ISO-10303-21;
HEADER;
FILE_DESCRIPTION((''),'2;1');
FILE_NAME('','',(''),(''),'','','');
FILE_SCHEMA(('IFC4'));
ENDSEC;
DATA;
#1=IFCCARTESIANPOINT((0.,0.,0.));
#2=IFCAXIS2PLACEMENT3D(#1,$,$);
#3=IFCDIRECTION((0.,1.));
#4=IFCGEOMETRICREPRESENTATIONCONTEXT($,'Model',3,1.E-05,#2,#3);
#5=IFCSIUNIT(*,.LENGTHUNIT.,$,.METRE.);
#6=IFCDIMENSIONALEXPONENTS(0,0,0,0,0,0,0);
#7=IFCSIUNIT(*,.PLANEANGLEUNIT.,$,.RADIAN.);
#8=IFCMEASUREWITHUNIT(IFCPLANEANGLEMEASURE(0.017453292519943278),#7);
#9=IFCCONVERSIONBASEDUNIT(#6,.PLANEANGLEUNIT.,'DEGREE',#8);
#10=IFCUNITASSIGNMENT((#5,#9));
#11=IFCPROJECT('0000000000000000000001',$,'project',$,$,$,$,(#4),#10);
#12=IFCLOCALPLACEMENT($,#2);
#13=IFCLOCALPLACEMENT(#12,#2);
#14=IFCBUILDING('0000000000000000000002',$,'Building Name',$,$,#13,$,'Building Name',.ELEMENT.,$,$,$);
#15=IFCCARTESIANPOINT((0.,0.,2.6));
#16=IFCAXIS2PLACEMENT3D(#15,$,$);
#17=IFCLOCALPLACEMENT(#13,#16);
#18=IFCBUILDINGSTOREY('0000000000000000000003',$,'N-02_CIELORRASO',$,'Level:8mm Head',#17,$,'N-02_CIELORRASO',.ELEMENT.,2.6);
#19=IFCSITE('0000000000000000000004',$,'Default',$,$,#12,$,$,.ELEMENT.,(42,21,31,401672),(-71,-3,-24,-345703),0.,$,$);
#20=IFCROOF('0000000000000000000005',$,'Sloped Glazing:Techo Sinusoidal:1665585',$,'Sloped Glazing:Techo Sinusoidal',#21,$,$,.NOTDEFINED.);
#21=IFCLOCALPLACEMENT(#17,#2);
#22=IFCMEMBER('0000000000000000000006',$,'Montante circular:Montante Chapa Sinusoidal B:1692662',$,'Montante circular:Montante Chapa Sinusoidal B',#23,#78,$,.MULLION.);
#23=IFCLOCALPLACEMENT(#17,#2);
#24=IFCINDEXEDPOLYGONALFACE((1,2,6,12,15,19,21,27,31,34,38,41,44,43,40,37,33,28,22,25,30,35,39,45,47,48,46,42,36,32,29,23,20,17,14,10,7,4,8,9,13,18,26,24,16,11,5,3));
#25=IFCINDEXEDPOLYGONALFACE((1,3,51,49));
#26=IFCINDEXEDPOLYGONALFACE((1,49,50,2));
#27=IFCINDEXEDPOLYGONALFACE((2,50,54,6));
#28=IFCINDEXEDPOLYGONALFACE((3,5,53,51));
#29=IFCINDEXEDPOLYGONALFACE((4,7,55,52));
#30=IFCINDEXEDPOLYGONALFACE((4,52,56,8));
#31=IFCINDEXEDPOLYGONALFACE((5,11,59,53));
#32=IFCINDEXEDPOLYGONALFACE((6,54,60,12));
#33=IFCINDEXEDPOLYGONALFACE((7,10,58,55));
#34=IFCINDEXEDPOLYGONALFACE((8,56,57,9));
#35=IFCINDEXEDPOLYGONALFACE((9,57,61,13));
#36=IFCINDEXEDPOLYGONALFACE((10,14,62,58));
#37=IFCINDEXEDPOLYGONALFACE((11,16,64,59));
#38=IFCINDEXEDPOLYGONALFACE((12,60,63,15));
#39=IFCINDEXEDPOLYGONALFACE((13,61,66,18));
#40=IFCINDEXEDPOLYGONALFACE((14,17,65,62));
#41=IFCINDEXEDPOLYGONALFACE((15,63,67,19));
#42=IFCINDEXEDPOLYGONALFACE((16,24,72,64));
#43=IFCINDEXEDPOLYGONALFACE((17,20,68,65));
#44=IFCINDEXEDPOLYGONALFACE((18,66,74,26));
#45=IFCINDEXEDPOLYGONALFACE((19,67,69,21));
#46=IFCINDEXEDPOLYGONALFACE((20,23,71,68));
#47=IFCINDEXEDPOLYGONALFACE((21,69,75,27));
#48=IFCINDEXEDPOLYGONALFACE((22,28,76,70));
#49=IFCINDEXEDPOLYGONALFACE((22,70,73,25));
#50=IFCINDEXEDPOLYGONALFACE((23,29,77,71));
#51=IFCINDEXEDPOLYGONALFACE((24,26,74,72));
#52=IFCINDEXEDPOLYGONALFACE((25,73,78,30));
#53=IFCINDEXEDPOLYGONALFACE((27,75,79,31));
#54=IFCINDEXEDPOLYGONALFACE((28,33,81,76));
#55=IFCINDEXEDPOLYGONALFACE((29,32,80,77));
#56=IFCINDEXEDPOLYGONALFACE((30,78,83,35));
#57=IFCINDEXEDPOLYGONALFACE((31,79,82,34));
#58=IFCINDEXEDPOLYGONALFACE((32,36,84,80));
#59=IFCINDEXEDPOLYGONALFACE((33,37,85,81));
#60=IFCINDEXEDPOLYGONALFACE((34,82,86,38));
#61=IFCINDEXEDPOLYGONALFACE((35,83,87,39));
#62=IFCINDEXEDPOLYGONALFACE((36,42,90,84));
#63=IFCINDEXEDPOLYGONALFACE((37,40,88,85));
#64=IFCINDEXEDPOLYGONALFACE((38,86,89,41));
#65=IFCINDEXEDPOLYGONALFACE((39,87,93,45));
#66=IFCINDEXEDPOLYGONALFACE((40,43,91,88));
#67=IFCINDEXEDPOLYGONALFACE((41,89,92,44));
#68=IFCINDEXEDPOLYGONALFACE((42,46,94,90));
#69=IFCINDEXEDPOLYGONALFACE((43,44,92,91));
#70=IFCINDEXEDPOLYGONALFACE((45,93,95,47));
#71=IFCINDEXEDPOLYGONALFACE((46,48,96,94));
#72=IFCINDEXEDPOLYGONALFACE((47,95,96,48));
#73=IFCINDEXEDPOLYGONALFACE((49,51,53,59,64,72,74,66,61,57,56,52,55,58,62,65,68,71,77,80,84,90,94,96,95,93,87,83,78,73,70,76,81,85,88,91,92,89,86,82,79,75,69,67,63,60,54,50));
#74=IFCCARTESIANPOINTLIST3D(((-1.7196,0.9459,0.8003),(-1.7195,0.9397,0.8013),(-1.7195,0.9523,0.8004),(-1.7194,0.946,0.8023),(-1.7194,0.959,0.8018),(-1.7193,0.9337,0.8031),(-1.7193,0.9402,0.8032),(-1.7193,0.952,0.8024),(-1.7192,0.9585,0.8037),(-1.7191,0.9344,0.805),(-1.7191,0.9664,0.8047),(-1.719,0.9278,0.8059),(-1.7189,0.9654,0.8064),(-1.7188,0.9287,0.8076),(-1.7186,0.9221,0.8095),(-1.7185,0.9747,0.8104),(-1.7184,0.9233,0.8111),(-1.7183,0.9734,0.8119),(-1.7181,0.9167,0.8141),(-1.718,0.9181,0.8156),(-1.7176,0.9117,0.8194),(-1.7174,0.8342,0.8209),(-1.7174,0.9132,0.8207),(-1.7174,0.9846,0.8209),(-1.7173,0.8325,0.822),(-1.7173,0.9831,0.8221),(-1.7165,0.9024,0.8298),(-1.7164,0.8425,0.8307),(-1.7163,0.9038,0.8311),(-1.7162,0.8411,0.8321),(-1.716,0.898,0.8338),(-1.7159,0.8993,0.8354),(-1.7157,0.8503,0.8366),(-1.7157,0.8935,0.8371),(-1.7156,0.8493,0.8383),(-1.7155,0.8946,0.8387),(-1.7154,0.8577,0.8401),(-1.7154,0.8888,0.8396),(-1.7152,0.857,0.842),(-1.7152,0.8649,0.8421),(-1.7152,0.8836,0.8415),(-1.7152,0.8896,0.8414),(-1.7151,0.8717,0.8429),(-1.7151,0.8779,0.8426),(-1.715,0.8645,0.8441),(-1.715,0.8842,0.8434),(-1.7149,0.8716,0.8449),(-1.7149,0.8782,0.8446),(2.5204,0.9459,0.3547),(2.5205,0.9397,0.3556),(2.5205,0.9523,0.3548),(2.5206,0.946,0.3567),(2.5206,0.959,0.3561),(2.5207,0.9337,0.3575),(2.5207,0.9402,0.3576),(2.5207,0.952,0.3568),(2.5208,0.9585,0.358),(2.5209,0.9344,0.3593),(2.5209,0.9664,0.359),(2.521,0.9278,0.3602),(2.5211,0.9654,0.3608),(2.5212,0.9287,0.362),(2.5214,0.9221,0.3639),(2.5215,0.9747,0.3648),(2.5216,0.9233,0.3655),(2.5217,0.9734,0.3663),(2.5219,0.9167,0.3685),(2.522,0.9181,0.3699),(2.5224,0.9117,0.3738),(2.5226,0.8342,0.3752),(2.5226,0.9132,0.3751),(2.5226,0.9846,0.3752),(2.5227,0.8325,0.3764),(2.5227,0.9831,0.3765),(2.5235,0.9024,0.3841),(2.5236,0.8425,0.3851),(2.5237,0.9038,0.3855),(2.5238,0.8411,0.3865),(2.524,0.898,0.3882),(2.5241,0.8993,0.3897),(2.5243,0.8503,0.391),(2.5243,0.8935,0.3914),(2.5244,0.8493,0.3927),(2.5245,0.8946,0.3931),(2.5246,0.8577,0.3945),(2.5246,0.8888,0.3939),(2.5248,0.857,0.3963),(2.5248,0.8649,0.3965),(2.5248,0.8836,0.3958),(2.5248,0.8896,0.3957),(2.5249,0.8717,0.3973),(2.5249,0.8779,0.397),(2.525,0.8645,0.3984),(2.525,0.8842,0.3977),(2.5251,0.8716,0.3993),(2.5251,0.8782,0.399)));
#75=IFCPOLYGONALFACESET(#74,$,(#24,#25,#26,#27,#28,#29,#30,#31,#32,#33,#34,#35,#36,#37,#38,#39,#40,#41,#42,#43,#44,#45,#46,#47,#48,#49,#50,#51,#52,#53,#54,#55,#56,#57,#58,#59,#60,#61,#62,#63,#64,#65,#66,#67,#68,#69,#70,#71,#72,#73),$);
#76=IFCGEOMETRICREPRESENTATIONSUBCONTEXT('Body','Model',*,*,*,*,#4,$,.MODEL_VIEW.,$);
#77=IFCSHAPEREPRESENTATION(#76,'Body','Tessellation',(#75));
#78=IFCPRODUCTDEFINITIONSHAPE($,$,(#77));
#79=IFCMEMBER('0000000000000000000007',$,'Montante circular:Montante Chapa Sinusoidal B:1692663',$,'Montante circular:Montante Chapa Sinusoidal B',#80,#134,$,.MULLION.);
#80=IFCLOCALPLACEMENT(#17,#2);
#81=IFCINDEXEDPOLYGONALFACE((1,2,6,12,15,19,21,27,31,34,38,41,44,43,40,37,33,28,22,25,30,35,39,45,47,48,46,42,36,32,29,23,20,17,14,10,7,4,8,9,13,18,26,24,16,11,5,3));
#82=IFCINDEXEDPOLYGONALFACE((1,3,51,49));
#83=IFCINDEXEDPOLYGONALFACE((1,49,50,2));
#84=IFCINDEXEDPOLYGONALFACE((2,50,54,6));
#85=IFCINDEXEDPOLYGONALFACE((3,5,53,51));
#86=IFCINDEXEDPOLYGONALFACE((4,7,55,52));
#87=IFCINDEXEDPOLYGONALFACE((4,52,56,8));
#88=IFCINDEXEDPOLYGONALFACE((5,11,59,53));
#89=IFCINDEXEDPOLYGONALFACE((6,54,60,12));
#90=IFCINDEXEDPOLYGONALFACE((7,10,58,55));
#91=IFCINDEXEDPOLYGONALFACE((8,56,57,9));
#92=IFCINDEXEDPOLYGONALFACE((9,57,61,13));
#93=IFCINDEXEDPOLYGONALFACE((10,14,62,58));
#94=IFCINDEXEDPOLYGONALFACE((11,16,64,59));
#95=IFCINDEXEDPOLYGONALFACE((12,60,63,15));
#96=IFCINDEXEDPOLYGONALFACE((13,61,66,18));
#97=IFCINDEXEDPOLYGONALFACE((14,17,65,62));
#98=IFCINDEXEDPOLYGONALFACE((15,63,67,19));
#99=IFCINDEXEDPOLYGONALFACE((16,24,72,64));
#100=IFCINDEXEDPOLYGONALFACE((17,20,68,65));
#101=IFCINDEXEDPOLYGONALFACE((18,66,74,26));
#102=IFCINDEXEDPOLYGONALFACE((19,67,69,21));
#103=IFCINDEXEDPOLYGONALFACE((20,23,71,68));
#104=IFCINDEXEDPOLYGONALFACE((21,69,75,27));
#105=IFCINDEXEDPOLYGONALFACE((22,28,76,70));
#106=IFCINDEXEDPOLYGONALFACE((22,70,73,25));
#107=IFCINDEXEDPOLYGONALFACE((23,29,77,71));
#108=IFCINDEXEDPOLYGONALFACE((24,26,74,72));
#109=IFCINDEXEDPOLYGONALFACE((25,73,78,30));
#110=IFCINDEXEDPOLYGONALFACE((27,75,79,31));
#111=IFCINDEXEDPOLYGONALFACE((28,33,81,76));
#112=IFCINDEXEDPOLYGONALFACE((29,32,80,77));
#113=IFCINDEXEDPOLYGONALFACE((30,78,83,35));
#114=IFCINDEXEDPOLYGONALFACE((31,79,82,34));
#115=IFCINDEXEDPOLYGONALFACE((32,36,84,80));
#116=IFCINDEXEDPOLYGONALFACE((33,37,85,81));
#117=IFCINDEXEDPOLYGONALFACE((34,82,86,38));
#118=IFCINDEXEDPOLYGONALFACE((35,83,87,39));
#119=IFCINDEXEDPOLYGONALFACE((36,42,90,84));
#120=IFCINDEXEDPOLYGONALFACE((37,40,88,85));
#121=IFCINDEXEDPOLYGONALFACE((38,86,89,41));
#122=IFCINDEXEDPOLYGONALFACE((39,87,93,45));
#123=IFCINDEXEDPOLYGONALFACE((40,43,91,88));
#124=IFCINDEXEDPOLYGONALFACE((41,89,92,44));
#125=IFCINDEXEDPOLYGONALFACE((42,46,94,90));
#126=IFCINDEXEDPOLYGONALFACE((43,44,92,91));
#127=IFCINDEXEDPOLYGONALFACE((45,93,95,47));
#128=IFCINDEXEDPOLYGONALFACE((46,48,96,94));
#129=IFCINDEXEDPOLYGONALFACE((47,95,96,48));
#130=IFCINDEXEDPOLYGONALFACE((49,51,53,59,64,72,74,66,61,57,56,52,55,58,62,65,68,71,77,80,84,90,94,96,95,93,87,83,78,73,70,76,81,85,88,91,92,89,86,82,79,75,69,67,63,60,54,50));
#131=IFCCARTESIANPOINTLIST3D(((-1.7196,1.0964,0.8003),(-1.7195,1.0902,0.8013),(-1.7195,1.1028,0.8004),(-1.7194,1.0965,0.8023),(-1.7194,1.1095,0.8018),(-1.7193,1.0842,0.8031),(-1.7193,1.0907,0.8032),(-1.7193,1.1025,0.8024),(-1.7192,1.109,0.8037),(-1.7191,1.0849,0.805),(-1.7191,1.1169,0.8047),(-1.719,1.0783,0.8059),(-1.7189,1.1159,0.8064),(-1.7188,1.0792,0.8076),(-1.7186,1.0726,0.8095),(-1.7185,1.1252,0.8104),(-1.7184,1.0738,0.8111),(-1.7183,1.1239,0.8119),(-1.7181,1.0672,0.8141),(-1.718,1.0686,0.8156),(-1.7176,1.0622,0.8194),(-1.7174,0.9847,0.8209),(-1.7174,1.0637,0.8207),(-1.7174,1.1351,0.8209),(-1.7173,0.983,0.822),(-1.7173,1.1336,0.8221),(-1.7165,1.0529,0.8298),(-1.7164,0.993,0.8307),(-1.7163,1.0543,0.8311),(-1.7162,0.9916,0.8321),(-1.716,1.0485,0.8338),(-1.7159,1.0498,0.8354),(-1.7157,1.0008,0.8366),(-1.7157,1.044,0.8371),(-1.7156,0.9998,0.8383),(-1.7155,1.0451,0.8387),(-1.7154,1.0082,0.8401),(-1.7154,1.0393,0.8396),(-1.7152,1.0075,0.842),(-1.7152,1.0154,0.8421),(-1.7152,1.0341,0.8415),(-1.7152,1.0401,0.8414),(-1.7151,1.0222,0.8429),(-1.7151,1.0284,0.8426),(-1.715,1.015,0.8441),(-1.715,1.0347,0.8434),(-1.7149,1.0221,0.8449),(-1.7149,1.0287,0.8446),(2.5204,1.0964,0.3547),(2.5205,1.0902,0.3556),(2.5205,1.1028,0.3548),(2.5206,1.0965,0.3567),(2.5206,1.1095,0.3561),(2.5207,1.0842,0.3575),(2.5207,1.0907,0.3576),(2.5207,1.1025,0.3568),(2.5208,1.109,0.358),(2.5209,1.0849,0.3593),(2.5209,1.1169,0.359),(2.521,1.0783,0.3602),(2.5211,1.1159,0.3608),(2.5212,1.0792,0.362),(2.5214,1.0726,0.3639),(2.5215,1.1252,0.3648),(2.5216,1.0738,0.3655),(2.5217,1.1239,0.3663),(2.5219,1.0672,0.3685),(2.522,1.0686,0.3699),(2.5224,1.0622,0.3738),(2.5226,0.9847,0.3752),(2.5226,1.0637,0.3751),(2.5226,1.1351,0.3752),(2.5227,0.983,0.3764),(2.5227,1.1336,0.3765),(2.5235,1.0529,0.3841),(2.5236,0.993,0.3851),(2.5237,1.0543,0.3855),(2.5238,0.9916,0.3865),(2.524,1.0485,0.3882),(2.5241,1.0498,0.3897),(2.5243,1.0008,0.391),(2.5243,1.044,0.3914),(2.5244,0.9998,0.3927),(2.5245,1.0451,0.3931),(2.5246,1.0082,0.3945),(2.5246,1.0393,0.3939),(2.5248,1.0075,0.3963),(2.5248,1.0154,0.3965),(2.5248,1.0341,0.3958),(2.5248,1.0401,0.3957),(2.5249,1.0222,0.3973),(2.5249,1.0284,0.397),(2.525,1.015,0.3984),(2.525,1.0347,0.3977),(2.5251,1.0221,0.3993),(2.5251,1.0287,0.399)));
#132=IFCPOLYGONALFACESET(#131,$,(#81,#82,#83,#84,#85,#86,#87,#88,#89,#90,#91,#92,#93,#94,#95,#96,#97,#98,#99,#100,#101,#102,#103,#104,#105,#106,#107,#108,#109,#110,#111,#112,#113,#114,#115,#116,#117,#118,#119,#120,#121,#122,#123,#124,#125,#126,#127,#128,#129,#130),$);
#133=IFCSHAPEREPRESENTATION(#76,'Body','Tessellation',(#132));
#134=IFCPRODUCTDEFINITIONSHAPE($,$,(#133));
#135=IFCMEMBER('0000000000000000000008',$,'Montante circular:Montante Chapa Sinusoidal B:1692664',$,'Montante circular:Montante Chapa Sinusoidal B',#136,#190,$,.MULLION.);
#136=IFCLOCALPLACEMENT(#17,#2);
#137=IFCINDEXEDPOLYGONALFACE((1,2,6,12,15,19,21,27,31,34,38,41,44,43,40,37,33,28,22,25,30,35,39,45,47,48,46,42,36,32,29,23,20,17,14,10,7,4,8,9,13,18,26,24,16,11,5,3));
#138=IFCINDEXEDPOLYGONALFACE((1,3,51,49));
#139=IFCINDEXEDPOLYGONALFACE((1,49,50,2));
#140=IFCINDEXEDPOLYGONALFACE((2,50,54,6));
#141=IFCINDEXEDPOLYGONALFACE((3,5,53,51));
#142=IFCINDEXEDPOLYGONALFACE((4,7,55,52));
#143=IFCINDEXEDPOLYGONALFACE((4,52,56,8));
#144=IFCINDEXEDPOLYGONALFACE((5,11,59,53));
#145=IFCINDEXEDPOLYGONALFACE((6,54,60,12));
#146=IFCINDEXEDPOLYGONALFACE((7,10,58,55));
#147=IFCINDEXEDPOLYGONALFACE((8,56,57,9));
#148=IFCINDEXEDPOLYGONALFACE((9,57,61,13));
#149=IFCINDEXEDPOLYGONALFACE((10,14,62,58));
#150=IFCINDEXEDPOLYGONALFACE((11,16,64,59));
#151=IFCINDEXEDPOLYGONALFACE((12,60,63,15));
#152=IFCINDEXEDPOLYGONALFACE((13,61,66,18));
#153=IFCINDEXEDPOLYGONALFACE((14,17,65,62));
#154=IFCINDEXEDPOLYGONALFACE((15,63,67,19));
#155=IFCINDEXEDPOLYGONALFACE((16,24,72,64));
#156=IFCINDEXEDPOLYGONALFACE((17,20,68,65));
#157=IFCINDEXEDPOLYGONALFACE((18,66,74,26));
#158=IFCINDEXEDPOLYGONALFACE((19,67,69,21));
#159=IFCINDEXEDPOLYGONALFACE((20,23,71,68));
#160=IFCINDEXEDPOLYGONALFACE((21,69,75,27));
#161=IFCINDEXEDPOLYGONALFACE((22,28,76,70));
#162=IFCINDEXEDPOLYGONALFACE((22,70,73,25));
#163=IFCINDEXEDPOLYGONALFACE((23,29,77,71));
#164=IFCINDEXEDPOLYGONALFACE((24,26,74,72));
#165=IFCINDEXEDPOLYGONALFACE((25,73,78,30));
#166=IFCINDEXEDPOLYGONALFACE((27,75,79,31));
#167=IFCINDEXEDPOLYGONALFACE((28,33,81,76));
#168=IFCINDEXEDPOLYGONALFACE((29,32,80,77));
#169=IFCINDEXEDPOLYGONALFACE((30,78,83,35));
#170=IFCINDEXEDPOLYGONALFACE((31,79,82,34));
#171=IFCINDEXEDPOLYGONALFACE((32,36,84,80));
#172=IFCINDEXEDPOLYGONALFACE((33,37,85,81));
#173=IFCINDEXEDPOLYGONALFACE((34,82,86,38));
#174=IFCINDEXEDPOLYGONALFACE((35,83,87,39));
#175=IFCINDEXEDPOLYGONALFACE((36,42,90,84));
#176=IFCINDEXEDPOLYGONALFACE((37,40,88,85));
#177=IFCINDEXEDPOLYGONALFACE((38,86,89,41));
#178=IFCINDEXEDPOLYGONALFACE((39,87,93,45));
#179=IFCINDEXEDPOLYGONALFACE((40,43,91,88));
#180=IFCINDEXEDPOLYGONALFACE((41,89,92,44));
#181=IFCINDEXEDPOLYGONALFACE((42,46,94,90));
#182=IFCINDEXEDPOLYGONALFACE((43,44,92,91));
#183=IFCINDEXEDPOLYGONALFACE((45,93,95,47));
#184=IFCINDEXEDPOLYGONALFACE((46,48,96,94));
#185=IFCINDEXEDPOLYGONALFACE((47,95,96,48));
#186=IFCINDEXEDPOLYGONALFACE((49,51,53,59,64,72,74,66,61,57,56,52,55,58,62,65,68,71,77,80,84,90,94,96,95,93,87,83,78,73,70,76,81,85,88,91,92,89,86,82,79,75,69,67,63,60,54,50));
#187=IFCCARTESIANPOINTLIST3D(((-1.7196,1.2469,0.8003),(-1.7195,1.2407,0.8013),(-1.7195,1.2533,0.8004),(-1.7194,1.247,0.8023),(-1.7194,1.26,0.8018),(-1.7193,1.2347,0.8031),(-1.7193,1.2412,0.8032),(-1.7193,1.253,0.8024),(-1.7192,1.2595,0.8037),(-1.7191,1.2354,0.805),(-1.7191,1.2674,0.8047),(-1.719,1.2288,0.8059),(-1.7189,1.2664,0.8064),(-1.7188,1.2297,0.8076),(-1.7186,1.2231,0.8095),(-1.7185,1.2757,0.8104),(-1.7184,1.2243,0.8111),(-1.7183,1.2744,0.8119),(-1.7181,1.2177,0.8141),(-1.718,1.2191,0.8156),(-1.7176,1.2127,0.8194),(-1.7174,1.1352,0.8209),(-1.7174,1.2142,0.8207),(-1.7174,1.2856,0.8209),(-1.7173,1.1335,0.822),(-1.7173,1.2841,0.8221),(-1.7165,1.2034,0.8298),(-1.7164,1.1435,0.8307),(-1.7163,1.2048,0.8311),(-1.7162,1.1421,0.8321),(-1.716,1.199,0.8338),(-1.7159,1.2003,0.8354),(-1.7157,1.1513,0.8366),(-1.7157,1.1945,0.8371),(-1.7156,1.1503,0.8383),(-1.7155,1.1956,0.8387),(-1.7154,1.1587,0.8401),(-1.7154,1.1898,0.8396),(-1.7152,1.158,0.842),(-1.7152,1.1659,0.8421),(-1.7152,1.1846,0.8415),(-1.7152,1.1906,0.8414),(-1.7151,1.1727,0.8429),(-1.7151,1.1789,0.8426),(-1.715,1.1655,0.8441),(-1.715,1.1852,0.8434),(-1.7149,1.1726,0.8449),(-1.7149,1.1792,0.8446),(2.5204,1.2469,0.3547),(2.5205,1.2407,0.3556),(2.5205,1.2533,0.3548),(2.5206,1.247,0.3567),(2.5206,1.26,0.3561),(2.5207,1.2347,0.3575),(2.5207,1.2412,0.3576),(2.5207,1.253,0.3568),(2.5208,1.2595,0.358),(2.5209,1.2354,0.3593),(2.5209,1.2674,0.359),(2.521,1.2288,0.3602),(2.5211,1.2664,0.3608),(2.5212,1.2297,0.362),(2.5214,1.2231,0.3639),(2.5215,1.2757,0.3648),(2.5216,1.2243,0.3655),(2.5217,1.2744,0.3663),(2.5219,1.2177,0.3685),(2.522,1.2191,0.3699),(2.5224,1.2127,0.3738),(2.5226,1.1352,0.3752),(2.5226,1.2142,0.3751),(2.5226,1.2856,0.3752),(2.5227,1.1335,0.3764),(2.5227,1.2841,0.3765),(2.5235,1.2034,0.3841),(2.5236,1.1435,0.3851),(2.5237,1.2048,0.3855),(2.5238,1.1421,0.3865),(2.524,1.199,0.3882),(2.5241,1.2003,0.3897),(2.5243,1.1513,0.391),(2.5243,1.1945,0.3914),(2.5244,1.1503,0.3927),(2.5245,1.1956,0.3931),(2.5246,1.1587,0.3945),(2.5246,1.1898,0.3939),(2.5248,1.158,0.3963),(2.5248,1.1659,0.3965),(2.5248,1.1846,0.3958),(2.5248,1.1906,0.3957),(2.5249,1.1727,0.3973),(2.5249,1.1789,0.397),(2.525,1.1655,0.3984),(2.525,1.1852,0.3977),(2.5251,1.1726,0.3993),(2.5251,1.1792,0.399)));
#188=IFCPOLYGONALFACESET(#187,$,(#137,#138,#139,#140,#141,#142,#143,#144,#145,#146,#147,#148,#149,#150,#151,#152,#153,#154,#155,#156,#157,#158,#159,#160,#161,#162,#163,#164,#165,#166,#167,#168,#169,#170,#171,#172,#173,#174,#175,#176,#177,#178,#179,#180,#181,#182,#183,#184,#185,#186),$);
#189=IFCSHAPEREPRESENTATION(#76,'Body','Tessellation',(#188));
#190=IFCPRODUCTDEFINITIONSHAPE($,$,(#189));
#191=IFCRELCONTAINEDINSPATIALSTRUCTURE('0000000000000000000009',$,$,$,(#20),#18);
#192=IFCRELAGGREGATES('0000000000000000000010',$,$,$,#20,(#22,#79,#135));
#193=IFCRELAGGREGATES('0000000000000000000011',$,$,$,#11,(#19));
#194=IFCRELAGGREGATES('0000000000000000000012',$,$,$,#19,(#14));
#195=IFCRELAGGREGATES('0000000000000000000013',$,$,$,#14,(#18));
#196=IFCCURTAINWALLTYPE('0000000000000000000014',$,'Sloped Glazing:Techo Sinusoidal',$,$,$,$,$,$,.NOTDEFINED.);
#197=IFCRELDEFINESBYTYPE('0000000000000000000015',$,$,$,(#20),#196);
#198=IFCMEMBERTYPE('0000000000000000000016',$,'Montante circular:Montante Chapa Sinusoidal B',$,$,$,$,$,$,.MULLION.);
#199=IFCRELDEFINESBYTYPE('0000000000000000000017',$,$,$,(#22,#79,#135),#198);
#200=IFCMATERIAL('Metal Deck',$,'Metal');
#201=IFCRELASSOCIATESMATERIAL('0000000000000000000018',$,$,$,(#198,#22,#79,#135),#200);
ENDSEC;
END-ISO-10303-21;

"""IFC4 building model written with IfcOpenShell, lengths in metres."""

from ifc_helpers import new_model, entity, si_unit, converted_unit, direction, frame, origin, place, context, subcontext, project, spatial, indexed_curve, outline, extrude, source, transform, mapped, material, type_object, type_shapes, element, aggregate, save


model = new_model("IFC4")

# Units and contexts
model_context = context("Model", 3, precision=1e-05, world=origin(), true_north=direction((0.0, 1.0)))
body_context = subcontext(model_context, "Body", "Model", "MODEL_VIEW")
ifc_project = project(units=[si_unit("LENGTHUNIT", "METRE"), converted_unit("PLANEANGLEUNIT", "DEGREE", entity("IfcPlaneAngleMeasure", 0.017453292519943278), si_unit("PLANEANGLEUNIT", "RADIAN"), dimensions=[0, 0, 0, 0, 0, 0, 0])], contexts=[model_context])

# Site, building, storey
site_placement = place(None, origin())
site = spatial("IfcSite", under=ifc_project, at=site_placement, Name="Default", CompositionType="ELEMENT", RefLatitude=(42, 21, 31, 401672), RefLongitude=(-71, -3, -24, -345703), RefElevation=0.0)
building_placement = place(site_placement, origin())
building = spatial("IfcBuilding", under=site, at=building_placement, Name="Building Name", LongName="Building Name", CompositionType="ELEMENT")
storey_placement = place(building_placement, frame((0.0, 0.0, 2.6)))
storey = spatial("IfcBuildingStorey", under=building, at=storey_placement, Name="N-02_CIELORRASO", ObjectType="Level:8mm Head", LongName="N-02_CIELORRASO", CompositionType="ELEMENT", Elevation=2.6)

# Roof, members
curtain_wall_type = type_object("IfcCurtainWallType", Name="Sloped Glazing:Techo Sinusoidal", PredefinedType="NOTDEFINED")
roof_placement = place(storey_placement, frame((0.0, 0.0, -2.6)))
roof = element("IfcRoof", 1, at=roof_placement, inside=storey, type_object=curtain_wall_type, Name="Sloped Glazing:Techo Sinusoidal:1665585", ObjectType="Sloped Glazing:Techo Sinusoidal", PredefinedType="NOTDEFINED")
ifc_material = material(Name="Metal Deck", Category="Metal")
member_type = type_object("IfcMemberType", Name="Montante circular:Montante Chapa Sinusoidal B", PredefinedType="MULLION", material=ifc_material)
shared_shape = source(origin(), body_context, "Body", "SweptSolid", [
    extrude(outline(indexed_curve([(0.0595, -0.0443), (0.0615, -0.0443), (0.0603, -0.031), (0.0572, -0.0213), (0.053, -0.0138), (0.0481, -0.0078), (0.0427, -0.003), (0.0372, 0.0005), (0.0315, 0.0029), (0.0259, 0.0044), (0.0203, 0.0051), (0.0146, 0.005), (0.0084, 0.0041), (-0.0053, 0.0009), (-0.0123, -0.0005), (-0.0191, -0.0012), (-0.0256, -0.001), (-0.0317, 0.0001), (-0.0375, 0.0019), (-0.0428, 0.0046), (-0.0477, 0.0081), (-0.0522, 0.0128), (-0.0563, 0.0191), (-0.0597, 0.0282), (-0.0617, 0.0421), (-0.0637, 0.042), (-0.0616, 0.0277), (-0.0581, 0.0182), (-0.0537, 0.0116), (-0.049, 0.0066), (-0.0438, 0.0028), (-0.0382, 0.0001), (-0.0322, -0.0019), (-0.0258, -0.003), (-0.019, -0.0032), (-0.012, -0.0025), (-0.0048, -0.0011), (0.0088, 0.0021), (0.0147, 0.003), (0.0202, 0.0031), (0.0255, 0.0024), (0.0309, 0.001), (0.0362, -0.0013), (0.0415, -0.0046), (0.0466, -0.0092), (0.0513, -0.0149), (0.0554, -0.0221), (0.0584, -0.0314), (0.0595, -0.0443)], self_intersect=False)), frame((-0.007, 0.0228, -4.2634), z_axis=(0.0, 0.0, 1.0), x_axis=(-0.819152, -0.573576, 0.0)), (0.0, 0.0, 1.0), 4.2634),
])
type_shapes(member_type, [shared_shape])
member_1_placement = place(roof_placement, frame((-1.7148, 0.9154, 3.4456), z_axis=(-0.994522, 0.0, 0.104528), x_axis=(0.0, 1.0, 0.0)))
member_1 = element("IfcMember", 2, at=member_1_placement, type_object=member_type, material=ifc_material, Name="Montante circular:Montante Chapa Sinusoidal B:1692662", ObjectType="Montante circular:Montante Chapa Sinusoidal B", PredefinedType="MULLION", context=body_context, shape_type="MappedRepresentation", body=[
    mapped(shared_shape, transform((0.0, 0.0, 0.0), scale=1.0)),
])
member_2_placement = place(roof_placement, frame((-1.7148, 1.0659, 3.4456), z_axis=(-0.994522, 0.0, 0.104528), x_axis=(0.0, 1.0, 0.0)))
member_2 = element("IfcMember", 3, at=member_2_placement, type_object=member_type, material=ifc_material, Name="Montante circular:Montante Chapa Sinusoidal B:1692663", ObjectType="Montante circular:Montante Chapa Sinusoidal B", PredefinedType="MULLION", context=body_context, shape_type="MappedRepresentation", body=[
    mapped(shared_shape, transform((0.0, 0.0, 0.0), scale=1.0)),
])
member_3_placement = place(roof_placement, frame((-1.7148, 1.2164, 3.4456), z_axis=(-0.994522, 0.0, 0.104528), x_axis=(0.0, 1.0, 0.0)))
member_3 = element("IfcMember", 4, at=member_3_placement, type_object=member_type, material=ifc_material, Name="Montante circular:Montante Chapa Sinusoidal B:1692664", ObjectType="Montante circular:Montante Chapa Sinusoidal B", PredefinedType="MULLION", context=body_context, shape_type="MappedRepresentation", body=[
    mapped(shared_shape, transform((0.0, 0.0, 0.0), scale=1.0)),
])
aggregate(roof, [member_1, member_2, member_3])

save(model, "model.ifc")
